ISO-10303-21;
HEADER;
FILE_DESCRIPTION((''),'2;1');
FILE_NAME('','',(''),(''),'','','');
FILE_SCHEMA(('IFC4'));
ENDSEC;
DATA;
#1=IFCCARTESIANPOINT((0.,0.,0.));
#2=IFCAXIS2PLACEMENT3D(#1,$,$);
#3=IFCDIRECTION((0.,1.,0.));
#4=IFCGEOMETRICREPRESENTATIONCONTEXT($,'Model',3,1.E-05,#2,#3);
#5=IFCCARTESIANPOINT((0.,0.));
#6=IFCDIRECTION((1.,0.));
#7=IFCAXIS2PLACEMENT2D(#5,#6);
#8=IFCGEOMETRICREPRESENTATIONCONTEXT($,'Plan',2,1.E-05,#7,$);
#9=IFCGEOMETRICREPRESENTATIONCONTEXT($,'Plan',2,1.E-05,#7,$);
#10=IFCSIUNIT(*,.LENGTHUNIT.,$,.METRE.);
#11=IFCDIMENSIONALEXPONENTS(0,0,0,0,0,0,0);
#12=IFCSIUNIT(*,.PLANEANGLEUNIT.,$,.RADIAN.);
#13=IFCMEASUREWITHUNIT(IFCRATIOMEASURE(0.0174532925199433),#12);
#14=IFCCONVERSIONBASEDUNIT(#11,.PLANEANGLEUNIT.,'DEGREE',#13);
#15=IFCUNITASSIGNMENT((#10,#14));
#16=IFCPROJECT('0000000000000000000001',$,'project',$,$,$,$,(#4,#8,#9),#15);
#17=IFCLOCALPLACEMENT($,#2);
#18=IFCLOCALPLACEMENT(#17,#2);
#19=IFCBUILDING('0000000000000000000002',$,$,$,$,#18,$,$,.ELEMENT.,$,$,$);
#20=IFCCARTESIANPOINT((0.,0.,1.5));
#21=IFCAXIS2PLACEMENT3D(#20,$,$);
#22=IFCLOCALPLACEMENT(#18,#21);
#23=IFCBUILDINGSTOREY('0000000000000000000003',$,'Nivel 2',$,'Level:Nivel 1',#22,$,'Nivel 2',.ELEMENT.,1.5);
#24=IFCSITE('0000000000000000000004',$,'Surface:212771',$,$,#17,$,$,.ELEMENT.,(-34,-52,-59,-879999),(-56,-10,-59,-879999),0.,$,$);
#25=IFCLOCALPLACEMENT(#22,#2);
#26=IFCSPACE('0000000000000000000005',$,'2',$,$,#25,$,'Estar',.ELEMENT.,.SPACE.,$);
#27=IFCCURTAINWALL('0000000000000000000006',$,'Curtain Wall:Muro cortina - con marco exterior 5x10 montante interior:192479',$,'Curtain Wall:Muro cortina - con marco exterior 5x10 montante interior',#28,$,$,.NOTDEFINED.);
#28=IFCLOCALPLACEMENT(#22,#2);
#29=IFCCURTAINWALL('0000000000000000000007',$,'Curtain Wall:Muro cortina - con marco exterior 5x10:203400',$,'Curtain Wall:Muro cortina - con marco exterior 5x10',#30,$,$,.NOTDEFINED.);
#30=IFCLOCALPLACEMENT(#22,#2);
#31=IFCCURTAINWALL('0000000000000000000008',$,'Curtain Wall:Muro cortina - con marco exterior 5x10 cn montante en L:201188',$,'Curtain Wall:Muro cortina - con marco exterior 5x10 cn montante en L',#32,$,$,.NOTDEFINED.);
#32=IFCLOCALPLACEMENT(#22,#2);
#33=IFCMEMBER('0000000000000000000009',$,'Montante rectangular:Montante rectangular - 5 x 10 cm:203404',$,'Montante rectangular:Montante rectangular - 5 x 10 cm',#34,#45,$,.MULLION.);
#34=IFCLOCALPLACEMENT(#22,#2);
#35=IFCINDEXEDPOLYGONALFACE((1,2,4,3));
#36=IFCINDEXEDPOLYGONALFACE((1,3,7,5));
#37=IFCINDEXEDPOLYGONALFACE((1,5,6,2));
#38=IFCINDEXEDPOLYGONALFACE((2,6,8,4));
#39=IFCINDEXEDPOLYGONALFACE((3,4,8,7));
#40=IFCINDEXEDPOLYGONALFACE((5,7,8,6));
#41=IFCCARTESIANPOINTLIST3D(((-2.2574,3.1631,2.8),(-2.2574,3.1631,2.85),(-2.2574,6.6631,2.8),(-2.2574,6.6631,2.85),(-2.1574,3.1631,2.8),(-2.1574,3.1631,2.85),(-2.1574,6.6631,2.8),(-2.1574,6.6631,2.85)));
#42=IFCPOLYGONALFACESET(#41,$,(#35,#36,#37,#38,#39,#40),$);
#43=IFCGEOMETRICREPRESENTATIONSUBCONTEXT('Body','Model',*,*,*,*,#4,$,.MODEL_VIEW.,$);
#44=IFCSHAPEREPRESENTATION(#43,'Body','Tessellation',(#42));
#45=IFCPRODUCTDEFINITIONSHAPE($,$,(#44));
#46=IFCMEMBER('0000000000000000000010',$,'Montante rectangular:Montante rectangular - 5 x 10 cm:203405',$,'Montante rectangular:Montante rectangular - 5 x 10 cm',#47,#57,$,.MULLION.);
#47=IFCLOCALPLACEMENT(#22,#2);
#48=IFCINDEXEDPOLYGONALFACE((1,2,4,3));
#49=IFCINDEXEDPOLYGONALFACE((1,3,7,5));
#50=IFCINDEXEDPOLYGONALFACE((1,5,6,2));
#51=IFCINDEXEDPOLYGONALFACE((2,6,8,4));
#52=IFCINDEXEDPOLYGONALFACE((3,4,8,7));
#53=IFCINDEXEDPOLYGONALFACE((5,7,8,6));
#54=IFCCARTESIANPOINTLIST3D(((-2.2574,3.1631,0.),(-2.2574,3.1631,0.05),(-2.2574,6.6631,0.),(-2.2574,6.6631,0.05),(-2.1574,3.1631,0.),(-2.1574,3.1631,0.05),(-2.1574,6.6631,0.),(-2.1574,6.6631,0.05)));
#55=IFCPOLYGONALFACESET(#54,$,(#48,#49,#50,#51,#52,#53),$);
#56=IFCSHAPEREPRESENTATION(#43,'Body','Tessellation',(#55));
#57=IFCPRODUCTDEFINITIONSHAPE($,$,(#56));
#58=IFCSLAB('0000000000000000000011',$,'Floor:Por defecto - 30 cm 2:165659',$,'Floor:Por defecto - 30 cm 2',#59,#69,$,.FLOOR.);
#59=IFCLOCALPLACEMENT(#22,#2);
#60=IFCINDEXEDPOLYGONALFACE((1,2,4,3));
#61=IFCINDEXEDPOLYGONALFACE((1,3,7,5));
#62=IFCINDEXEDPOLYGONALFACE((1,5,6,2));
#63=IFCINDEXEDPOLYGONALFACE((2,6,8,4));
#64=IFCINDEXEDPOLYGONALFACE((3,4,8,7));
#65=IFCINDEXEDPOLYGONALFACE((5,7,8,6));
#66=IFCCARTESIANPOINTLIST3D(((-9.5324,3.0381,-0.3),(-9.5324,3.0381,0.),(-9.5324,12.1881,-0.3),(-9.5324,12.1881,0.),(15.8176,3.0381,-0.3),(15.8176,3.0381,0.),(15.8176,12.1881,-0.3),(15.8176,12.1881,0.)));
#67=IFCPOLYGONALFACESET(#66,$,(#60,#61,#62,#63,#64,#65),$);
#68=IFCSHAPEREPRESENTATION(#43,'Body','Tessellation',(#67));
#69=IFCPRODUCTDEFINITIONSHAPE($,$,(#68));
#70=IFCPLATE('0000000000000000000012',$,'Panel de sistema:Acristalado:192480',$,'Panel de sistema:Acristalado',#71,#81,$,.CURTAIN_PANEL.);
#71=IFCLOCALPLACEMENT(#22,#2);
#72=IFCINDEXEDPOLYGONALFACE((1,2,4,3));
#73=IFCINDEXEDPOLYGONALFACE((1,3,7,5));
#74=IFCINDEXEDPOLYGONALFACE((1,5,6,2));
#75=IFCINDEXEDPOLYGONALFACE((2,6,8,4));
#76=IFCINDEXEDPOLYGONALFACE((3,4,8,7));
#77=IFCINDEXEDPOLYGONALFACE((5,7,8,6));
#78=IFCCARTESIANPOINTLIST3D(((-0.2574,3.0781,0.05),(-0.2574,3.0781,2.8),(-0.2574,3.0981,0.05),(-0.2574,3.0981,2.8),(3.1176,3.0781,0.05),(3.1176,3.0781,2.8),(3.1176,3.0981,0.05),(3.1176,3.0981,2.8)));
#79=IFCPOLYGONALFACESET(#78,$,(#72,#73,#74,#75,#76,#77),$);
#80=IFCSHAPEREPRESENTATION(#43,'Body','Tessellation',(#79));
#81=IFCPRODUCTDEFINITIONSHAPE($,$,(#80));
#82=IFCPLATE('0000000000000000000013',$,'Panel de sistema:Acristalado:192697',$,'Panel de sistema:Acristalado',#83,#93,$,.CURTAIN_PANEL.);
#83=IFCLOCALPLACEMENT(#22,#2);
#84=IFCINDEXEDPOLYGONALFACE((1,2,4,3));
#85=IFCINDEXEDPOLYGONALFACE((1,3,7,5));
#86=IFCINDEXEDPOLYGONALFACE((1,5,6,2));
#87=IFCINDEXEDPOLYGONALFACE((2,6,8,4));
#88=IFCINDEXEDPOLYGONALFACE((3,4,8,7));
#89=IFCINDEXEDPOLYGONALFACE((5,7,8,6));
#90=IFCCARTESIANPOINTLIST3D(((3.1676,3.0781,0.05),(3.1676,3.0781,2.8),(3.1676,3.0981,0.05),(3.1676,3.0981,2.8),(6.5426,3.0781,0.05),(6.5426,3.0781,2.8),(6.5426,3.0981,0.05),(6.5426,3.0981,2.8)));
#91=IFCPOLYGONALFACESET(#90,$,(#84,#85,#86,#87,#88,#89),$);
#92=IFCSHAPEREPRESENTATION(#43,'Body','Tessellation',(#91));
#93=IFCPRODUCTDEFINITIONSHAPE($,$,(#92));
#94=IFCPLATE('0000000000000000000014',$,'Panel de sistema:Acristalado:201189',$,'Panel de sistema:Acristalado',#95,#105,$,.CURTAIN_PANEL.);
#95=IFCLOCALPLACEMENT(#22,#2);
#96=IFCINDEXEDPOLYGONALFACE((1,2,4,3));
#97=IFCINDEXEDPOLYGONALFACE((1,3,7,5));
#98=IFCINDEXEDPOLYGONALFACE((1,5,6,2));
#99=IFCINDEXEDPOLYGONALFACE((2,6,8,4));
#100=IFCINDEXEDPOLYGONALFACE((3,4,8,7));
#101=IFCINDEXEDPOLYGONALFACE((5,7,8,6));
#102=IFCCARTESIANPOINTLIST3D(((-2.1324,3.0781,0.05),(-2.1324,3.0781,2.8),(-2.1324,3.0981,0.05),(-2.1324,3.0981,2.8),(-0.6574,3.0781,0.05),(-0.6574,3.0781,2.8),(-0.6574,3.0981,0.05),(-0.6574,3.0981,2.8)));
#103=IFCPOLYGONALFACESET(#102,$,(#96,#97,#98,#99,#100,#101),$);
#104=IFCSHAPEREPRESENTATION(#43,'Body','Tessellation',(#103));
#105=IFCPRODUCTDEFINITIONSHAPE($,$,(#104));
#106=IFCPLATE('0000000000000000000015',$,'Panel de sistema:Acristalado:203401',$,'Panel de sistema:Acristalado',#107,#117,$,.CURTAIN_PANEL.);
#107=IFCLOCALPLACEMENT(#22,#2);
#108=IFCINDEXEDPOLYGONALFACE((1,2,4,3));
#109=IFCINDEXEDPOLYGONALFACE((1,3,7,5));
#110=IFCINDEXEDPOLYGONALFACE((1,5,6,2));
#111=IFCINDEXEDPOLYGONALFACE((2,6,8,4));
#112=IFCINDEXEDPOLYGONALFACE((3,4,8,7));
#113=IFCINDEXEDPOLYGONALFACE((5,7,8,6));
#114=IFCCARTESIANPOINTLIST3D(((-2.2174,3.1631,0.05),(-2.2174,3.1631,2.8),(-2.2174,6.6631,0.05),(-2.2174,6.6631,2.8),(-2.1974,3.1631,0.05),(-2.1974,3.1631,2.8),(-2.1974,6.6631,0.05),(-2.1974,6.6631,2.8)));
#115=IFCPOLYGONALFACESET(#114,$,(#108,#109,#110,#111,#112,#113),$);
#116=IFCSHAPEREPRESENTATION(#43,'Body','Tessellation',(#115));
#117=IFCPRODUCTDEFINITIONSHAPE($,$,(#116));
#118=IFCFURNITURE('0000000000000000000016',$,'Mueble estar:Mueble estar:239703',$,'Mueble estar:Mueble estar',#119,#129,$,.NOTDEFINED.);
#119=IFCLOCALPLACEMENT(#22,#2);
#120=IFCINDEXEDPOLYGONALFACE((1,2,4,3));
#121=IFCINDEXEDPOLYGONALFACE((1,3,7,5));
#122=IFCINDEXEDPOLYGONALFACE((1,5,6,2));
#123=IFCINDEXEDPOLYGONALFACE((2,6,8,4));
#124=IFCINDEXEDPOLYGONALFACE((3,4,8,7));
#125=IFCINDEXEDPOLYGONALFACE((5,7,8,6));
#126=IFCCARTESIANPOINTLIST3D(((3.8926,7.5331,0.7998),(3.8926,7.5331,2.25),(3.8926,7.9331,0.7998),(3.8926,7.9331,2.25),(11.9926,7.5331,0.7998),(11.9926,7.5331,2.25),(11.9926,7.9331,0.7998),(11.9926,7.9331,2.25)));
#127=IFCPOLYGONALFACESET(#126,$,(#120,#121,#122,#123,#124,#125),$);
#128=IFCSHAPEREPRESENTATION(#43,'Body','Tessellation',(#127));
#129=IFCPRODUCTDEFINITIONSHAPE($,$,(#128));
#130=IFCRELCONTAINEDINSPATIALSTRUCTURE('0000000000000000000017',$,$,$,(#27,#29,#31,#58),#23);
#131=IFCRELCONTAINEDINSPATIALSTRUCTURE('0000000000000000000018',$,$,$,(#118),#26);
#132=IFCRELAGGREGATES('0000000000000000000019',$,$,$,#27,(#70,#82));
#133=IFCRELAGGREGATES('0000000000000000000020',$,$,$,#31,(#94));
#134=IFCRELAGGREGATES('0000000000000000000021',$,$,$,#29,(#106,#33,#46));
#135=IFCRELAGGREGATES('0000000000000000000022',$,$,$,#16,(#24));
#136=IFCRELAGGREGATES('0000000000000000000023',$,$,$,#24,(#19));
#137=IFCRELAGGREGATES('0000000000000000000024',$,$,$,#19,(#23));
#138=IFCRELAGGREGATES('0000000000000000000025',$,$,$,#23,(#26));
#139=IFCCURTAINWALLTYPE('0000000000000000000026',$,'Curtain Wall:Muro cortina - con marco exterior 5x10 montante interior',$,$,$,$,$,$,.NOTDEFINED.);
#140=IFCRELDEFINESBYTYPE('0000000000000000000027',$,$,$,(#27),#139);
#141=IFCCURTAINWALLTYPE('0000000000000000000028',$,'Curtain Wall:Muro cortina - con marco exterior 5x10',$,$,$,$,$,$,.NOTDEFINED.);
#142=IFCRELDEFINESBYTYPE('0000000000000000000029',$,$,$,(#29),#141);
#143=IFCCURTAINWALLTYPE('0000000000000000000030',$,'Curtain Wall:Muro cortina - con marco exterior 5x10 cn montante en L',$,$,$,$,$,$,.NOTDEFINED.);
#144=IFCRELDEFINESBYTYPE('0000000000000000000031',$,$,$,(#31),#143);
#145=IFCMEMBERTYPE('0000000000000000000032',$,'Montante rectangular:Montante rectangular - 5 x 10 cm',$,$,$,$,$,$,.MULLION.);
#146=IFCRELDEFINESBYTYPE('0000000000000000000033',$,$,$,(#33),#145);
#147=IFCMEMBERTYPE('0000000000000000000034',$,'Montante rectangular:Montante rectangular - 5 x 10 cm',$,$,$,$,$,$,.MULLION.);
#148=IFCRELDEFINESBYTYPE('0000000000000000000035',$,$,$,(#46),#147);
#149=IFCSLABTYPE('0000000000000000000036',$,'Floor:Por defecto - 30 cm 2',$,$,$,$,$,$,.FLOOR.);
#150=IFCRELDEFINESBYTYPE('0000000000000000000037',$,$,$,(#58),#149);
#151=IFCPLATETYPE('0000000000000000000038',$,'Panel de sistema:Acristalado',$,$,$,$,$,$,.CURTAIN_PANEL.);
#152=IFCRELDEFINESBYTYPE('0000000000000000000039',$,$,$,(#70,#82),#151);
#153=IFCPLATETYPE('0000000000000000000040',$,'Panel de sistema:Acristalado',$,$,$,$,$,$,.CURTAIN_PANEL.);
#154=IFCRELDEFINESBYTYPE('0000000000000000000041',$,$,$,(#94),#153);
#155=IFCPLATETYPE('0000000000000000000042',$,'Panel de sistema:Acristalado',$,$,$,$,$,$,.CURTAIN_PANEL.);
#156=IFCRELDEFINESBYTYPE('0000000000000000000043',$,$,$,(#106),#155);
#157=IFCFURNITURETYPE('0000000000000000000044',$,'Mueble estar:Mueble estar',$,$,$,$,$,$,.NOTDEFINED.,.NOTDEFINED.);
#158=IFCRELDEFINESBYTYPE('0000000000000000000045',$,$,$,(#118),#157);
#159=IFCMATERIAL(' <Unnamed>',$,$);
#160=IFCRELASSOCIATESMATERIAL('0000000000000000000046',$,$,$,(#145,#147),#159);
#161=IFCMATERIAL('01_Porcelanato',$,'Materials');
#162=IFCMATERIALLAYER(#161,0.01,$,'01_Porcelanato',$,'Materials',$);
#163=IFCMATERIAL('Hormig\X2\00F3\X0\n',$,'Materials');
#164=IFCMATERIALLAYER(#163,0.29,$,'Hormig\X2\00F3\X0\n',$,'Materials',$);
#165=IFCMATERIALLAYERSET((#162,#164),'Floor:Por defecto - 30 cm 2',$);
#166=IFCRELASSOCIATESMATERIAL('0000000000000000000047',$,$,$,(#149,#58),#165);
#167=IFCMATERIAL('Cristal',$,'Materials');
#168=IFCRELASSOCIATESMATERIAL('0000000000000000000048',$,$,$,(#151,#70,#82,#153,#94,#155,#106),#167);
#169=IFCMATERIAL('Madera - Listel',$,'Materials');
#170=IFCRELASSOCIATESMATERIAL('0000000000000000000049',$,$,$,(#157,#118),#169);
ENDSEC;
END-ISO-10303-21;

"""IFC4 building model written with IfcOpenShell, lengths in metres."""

from ifc_helpers import new_model, entity, si_unit, converted_unit, direction, frame, origin, origin_2d_with_axis, place, context, subcontext, project, spatial, polyline, indexed_curve, outline, extrude, shape, source, transform, mapped, material, layer, layer_set, type_object, type_shapes, element, aggregate, save


model = new_model("IFC4")

# Units and contexts
model_context = context("Model", 3, precision=1e-05, world=origin(), true_north=direction((0.0, 1.0, 0.0)))
plan_context_1 = context("Plan", 2, precision=1e-05, world=origin_2d_with_axis())
plan_context_2 = context("Plan", 2, precision=1e-05, world=origin_2d_with_axis())
body_context = subcontext(model_context, "Body", "Model", "MODEL_VIEW")
footprint_context = subcontext(model_context, "FootPrint", "Model", "MODEL_VIEW")
ifc_project = project(units=[si_unit("LENGTHUNIT", "METRE"), converted_unit("PLANEANGLEUNIT", "DEGREE", entity("IfcRatioMeasure", 0.0174532925199433), si_unit("PLANEANGLEUNIT", "RADIAN"), dimensions=[0, 0, 0, 0, 0, 0, 0])], contexts=[model_context, plan_context_1, plan_context_2])

# Site, building, storey
site_placement = place(None, origin())
site = spatial("IfcSite", under=ifc_project, at=site_placement, Name="Surface:212771", CompositionType="ELEMENT", RefLatitude=(-34, -52, -59, -879999), RefLongitude=(-56, -10, -59, -879999), RefElevation=0.0)
building_placement = place(site_placement, origin())
building = spatial("IfcBuilding", under=site, at=building_placement, CompositionType="ELEMENT")
storey_placement = place(building_placement, frame((0.0, 0.0, 1.5)))
storey = spatial("IfcBuildingStorey", under=building, at=storey_placement, Name="Nivel 2", ObjectType="Level:Nivel 1", LongName="Nivel 2", CompositionType="ELEMENT", Elevation=1.5)

# Curtain wall
curtain_wall_type_1 = type_object("IfcCurtainWallType", Name="Curtain Wall:Muro cortina - con marco exterior 5x10 montante interior", PredefinedType="NOTDEFINED")
curtain_wall_1_placement = place(storey_placement, frame((0.0, 0.0, -1.5)))
curtain_wall_1 = element("IfcCurtainWall", 1, at=curtain_wall_1_placement, inside=storey, type_object=curtain_wall_type_1, Name="Curtain Wall:Muro cortina - con marco exterior 5x10 montante interior:192479", ObjectType="Curtain Wall:Muro cortina - con marco exterior 5x10 montante interior", PredefinedType="NOTDEFINED")
ifc_material_1 = material(Name=" <Unnamed>")

# Curtain wall
curtain_wall_type_2 = type_object("IfcCurtainWallType", Name="Curtain Wall:Muro cortina - con marco exterior 5x10", PredefinedType="NOTDEFINED")
curtain_wall_2_placement = place(storey_placement, frame((0.0, 0.0, -1.5)))
curtain_wall_2 = element("IfcCurtainWall", 2, at=curtain_wall_2_placement, inside=storey, type_object=curtain_wall_type_2, Name="Curtain Wall:Muro cortina - con marco exterior 5x10:203400", ObjectType="Curtain Wall:Muro cortina - con marco exterior 5x10", PredefinedType="NOTDEFINED")

# Curtain wall
curtain_wall_type_3 = type_object("IfcCurtainWallType", Name="Curtain Wall:Muro cortina - con marco exterior 5x10 cn montante en L", PredefinedType="NOTDEFINED")
curtain_wall_3_placement = place(storey_placement, frame((0.0, 0.0, -1.5)))
curtain_wall_3 = element("IfcCurtainWall", 3, at=curtain_wall_3_placement, inside=storey, type_object=curtain_wall_type_3, Name="Curtain Wall:Muro cortina - con marco exterior 5x10 cn montante en L:201188", ObjectType="Curtain Wall:Muro cortina - con marco exterior 5x10 cn montante en L", PredefinedType="NOTDEFINED")

# Members
member_type_1 = type_object("IfcMemberType", Name="Montante rectangular:Montante rectangular - 5 x 10 cm", PredefinedType="MULLION", material=ifc_material_1)
shared_shape_1 = source(origin(), body_context, "Body", "SweptSolid", [
    extrude(outline(indexed_curve([(-0.05, -0.025), (0.05, -0.025), (0.05, 0.025), (-0.05, 0.025), (-0.05, -0.025)], self_intersect=False)), frame((-0.025, 0.0, -3.5), z_axis=(0.0, 0.0, 1.0), x_axis=(0.0, -1.0, 0.0)), (0.0, 0.0, 1.0), 3.5),
])
type_shapes(member_type_1, [shared_shape_1])
member_1_placement = place(storey_placement, frame((-2.2074, 6.6631, 2.85), z_axis=(0.0, 1.0, 0.0), x_axis=(0.0, 0.0, 1.0)))
member_1 = element("IfcMember", 4, at=member_1_placement, type_object=member_type_1, Name="Montante rectangular:Montante rectangular - 5 x 10 cm:203404", ObjectType="Montante rectangular:Montante rectangular - 5 x 10 cm", PredefinedType="MULLION", context=body_context, shape_type="MappedRepresentation", body=[
    mapped(shared_shape_1, transform((0.0, 0.0, 0.0), scale=1.0)),
])
member_type_2 = type_object("IfcMemberType", Name="Montante rectangular:Montante rectangular - 5 x 10 cm", PredefinedType="MULLION", material=ifc_material_1)
shared_shape_2 = source(origin(), body_context, "Body", "SweptSolid", [
    extrude(outline(indexed_curve([(-0.05, -0.025), (0.05, -0.025), (0.05, 0.025), (-0.05, 0.025), (-0.05, -0.025)], self_intersect=False)), frame((-0.025, 0.0, -3.5), z_axis=(0.0, 0.0, 1.0), x_axis=(0.0, -1.0, 0.0)), (0.0, 0.0, 1.0), 3.5),
])
type_shapes(member_type_2, [shared_shape_2])
member_2_placement = place(storey_placement, frame((-2.2074, 3.1631, 0.0), z_axis=(0.0, -1.0, 0.0), x_axis=(0.0, 0.0, -1.0)))
member_2 = element("IfcMember", 5, at=member_2_placement, type_object=member_type_2, Name="Montante rectangular:Montante rectangular - 5 x 10 cm:203405", ObjectType="Montante rectangular:Montante rectangular - 5 x 10 cm", PredefinedType="MULLION", context=body_context, shape_type="MappedRepresentation", body=[
    mapped(shared_shape_2, transform((0.0, 0.0, 0.0), scale=1.0)),
])

# Slab
ifc_material_2 = material(Name="01_Porcelanato", Category="Materials")
ifc_layer_1 = layer(ifc_material_2, 0.01, Name="01_Porcelanato", Category="Materials")
ifc_material_3 = material(Name="Hormigón", Category="Materials")
ifc_layer_2 = layer(ifc_material_3, 0.29, Name="Hormigón", Category="Materials")
ifc_layer_set = layer_set([ifc_layer_1, ifc_layer_2], Name="Floor:Por defecto - 30 cm 2")
slab_type = type_object("IfcSlabType", Name="Floor:Por defecto - 30 cm 2", PredefinedType="FLOOR", material=ifc_layer_set)
slab_placement = place(storey_placement, origin())
element("IfcSlab", 6, at=slab_placement, inside=storey, type_object=slab_type, material=ifc_layer_set, Name="Floor:Por defecto - 30 cm 2:165659", ObjectType="Floor:Por defecto - 30 cm 2", PredefinedType="FLOOR", context=body_context, shape_type="SweptSolid", body=[
    extrude(outline(indexed_curve([(-4.575, -12.675), (4.575, -12.675), (4.575, 12.675), (-4.575, 12.675), (-4.575, -12.675)], self_intersect=False)), frame((3.1426, 7.6131, 0.0), z_axis=(0.0, 0.0, -1.0), x_axis=(0.0, 1.0, 0.0)), (0.0, 0.0, 1.0), 0.3),
])

# Plates
ifc_material_4 = material(Name="Cristal", Category="Materials")
plate_type_1 = type_object("IfcPlateType", Name="Panel de sistema:Acristalado", PredefinedType="CURTAIN_PANEL", material=ifc_material_4)
shared_shape_3 = source(origin(), body_context, "Body", "SweptSolid", [
    extrude(outline(indexed_curve([(-0.01, -1.6875), (0.01, -1.6875), (0.01, 1.6875), (-0.01, 1.6875), (-0.01, -1.6875)], self_intersect=False)), frame((0.0, 0.0, 0.0), z_axis=(0.0, 0.0, 1.0), x_axis=(0.0, 1.0, 0.0)), (0.0, 0.0, 1.0), 2.75),
])
shared_shape_4 = source(origin(), footprint_context, "FootPrint", "Curve2D", [
    entity("IfcIndexedPolyCurve", entity("IfcCartesianPointList2D", [[1.6875, -0.01], [1.6875, 0.01], [-1.6875, 0.01], [-1.6875, -0.01], [1.6875, -0.01]]), None, False),
])
type_shapes(plate_type_1, [shared_shape_3, shared_shape_4])
plate_1_placement = place(curtain_wall_1_placement, frame((1.4301, 3.0881, 1.55)))
plate_1 = element("IfcPlate", 7, at=plate_1_placement, type_object=plate_type_1, material=ifc_material_4, Name="Panel de sistema:Acristalado:192480", ObjectType="Panel de sistema:Acristalado", PredefinedType="CURTAIN_PANEL", shapes=[
    shape(body_context, "Body", "MappedRepresentation", [mapped(shared_shape_3, transform((0.0, 0.0, 0.0), scale=1.0))]),
    shape(body_context, "Body", "MappedRepresentation", [mapped(shared_shape_4, transform((0.0, 0.0, 0.0), scale=1.0))]),
])
plate_2_placement = place(curtain_wall_1_placement, frame((4.8551, 3.0881, 1.55)))
plate_2 = element("IfcPlate", 8, at=plate_2_placement, type_object=plate_type_1, material=ifc_material_4, Name="Panel de sistema:Acristalado:192697", ObjectType="Panel de sistema:Acristalado", PredefinedType="CURTAIN_PANEL", shapes=[
    shape(body_context, "Body", "MappedRepresentation", [mapped(shared_shape_3, transform((0.0, 0.0, 0.0), scale=1.0))]),
    shape(body_context, "Body", "MappedRepresentation", [mapped(shared_shape_4, transform((0.0, 0.0, 0.0), scale=1.0))]),
])
aggregate(curtain_wall_1, [plate_1, plate_2])
plate_type_2 = type_object("IfcPlateType", Name="Panel de sistema:Acristalado", PredefinedType="CURTAIN_PANEL", material=ifc_material_4)
shared_shape_5 = source(origin(), body_context, "Body", "SweptSolid", [
    extrude(outline(polyline([(-0.7375, -0.01), (0.7375, -0.01), (0.7375, 0.01), (-0.7375, 0.01), (-0.7375, -0.01)])), frame((0.0, 0.0, 0.0), z_axis=(0.0, 0.0, -1.0), x_axis=(-1.0, 0.0, 0.0)), (0.0, 0.0, -1.0), 2.75),
])
shared_shape_6 = source(origin(), footprint_context, "FootPrint", "Curve2D", [
    entity("IfcIndexedPolyCurve", entity("IfcCartesianPointList2D", [[0.7375, -0.01], [0.7375, 0.01], [-0.7375, 0.01], [-0.7375, -0.01], [0.7375, -0.01]]), None, False),
])
type_shapes(plate_type_2, [shared_shape_5, shared_shape_6])
plate_3_placement = place(curtain_wall_3_placement, frame((-1.3949, 3.0881, 1.55), z_axis=(0.0, 0.0, 1.0), x_axis=(-1.0, 0.0, 0.0)))
plate_3 = element("IfcPlate", 9, at=plate_3_placement, type_object=plate_type_2, material=ifc_material_4, Name="Panel de sistema:Acristalado:201189", ObjectType="Panel de sistema:Acristalado", PredefinedType="CURTAIN_PANEL", shapes=[
    shape(body_context, "Body", "MappedRepresentation", [mapped(shared_shape_5, transform((0.0, 0.0, 0.0), scale=1.0))]),
    shape(body_context, "Body", "MappedRepresentation", [mapped(shared_shape_6, transform((0.0, 0.0, 0.0), scale=1.0))]),
])
aggregate(curtain_wall_3, [plate_3])
plate_type_3 = type_object("IfcPlateType", Name="Panel de sistema:Acristalado", PredefinedType="CURTAIN_PANEL", material=ifc_material_4)
shared_shape_7 = source(origin(), body_context, "Body", "SweptSolid", [
    extrude(outline(indexed_curve([(-0.01, -1.75), (0.01, -1.75), (0.01, 1.75), (-0.01, 1.75), (-0.01, -1.75)], self_intersect=False)), frame((0.0, 0.0, 0.0), z_axis=(0.0, 0.0, 1.0), x_axis=(0.0, 1.0, 0.0)), (0.0, 0.0, 1.0), 2.75),
])
shared_shape_8 = source(origin(), footprint_context, "FootPrint", "Curve2D", [
    entity("IfcIndexedPolyCurve", entity("IfcCartesianPointList2D", [[1.75, -0.01], [1.75, 0.01], [-1.75, 0.01], [-1.75, -0.01], [1.75, -0.01]]), None, False),
])
type_shapes(plate_type_3, [shared_shape_7, shared_shape_8])
plate_4_placement = place(curtain_wall_2_placement, frame((-2.2074, 4.9131, 1.55), z_axis=(0.0, 0.0, 1.0), x_axis=(0.0, 1.0, 0.0)))
plate_4 = element("IfcPlate", 10, at=plate_4_placement, type_object=plate_type_3, material=ifc_material_4, Name="Panel de sistema:Acristalado:203401", ObjectType="Panel de sistema:Acristalado", PredefinedType="CURTAIN_PANEL", shapes=[
    shape(body_context, "Body", "MappedRepresentation", [mapped(shared_shape_7, transform((0.0, 0.0, 0.0), scale=1.0))]),
    shape(body_context, "Body", "MappedRepresentation", [mapped(shared_shape_8, transform((0.0, 0.0, 0.0), scale=1.0))]),
])
aggregate(curtain_wall_2, [plate_4, member_1, member_2])

# Shared definitions
space_placement = place(storey_placement, origin())
space = spatial("IfcSpace", under=storey, at=space_placement, Name="2", LongName="Estar", CompositionType="ELEMENT", PredefinedType="SPACE")

# Furniture
ifc_material_5 = material(Name="Madera - Listel", Category="Materials")
furniture_type = type_object("IfcFurnitureType", Name="Mueble estar:Mueble estar", AssemblyPlace="NOTDEFINED", PredefinedType="NOTDEFINED", material=ifc_material_5)
shared_shape_9 = source(origin(), body_context, "Body", "SweptSolid", [
    extrude(outline(indexed_curve([(-4.05, -0.2), (4.05, -0.2), (4.05, 0.2), (-4.05, 0.2), (-4.05, -0.2)], self_intersect=False)), frame((7.9426, 7.7331, 2.2998), z_axis=(0.0, 0.0, 1.0), x_axis=(-1.0, 0.0, 0.0)), (0.0, 0.0, 1.0), 1.4502),
])
type_shapes(furniture_type, [shared_shape_9])
furniture_placement = place(space_placement, frame((0.0, 0.0, -1.5)))
element("IfcFurniture", 11, at=furniture_placement, inside=space, type_object=furniture_type, material=ifc_material_5, Name="Mueble estar:Mueble estar:239703", ObjectType="Mueble estar:Mueble estar", PredefinedType="NOTDEFINED", context=body_context, shape_type="MappedRepresentation", body=[
    mapped(shared_shape_9, transform((0.0, 0.0, 0.0), scale=1.0)),
])

save(model, "model.ifc")
